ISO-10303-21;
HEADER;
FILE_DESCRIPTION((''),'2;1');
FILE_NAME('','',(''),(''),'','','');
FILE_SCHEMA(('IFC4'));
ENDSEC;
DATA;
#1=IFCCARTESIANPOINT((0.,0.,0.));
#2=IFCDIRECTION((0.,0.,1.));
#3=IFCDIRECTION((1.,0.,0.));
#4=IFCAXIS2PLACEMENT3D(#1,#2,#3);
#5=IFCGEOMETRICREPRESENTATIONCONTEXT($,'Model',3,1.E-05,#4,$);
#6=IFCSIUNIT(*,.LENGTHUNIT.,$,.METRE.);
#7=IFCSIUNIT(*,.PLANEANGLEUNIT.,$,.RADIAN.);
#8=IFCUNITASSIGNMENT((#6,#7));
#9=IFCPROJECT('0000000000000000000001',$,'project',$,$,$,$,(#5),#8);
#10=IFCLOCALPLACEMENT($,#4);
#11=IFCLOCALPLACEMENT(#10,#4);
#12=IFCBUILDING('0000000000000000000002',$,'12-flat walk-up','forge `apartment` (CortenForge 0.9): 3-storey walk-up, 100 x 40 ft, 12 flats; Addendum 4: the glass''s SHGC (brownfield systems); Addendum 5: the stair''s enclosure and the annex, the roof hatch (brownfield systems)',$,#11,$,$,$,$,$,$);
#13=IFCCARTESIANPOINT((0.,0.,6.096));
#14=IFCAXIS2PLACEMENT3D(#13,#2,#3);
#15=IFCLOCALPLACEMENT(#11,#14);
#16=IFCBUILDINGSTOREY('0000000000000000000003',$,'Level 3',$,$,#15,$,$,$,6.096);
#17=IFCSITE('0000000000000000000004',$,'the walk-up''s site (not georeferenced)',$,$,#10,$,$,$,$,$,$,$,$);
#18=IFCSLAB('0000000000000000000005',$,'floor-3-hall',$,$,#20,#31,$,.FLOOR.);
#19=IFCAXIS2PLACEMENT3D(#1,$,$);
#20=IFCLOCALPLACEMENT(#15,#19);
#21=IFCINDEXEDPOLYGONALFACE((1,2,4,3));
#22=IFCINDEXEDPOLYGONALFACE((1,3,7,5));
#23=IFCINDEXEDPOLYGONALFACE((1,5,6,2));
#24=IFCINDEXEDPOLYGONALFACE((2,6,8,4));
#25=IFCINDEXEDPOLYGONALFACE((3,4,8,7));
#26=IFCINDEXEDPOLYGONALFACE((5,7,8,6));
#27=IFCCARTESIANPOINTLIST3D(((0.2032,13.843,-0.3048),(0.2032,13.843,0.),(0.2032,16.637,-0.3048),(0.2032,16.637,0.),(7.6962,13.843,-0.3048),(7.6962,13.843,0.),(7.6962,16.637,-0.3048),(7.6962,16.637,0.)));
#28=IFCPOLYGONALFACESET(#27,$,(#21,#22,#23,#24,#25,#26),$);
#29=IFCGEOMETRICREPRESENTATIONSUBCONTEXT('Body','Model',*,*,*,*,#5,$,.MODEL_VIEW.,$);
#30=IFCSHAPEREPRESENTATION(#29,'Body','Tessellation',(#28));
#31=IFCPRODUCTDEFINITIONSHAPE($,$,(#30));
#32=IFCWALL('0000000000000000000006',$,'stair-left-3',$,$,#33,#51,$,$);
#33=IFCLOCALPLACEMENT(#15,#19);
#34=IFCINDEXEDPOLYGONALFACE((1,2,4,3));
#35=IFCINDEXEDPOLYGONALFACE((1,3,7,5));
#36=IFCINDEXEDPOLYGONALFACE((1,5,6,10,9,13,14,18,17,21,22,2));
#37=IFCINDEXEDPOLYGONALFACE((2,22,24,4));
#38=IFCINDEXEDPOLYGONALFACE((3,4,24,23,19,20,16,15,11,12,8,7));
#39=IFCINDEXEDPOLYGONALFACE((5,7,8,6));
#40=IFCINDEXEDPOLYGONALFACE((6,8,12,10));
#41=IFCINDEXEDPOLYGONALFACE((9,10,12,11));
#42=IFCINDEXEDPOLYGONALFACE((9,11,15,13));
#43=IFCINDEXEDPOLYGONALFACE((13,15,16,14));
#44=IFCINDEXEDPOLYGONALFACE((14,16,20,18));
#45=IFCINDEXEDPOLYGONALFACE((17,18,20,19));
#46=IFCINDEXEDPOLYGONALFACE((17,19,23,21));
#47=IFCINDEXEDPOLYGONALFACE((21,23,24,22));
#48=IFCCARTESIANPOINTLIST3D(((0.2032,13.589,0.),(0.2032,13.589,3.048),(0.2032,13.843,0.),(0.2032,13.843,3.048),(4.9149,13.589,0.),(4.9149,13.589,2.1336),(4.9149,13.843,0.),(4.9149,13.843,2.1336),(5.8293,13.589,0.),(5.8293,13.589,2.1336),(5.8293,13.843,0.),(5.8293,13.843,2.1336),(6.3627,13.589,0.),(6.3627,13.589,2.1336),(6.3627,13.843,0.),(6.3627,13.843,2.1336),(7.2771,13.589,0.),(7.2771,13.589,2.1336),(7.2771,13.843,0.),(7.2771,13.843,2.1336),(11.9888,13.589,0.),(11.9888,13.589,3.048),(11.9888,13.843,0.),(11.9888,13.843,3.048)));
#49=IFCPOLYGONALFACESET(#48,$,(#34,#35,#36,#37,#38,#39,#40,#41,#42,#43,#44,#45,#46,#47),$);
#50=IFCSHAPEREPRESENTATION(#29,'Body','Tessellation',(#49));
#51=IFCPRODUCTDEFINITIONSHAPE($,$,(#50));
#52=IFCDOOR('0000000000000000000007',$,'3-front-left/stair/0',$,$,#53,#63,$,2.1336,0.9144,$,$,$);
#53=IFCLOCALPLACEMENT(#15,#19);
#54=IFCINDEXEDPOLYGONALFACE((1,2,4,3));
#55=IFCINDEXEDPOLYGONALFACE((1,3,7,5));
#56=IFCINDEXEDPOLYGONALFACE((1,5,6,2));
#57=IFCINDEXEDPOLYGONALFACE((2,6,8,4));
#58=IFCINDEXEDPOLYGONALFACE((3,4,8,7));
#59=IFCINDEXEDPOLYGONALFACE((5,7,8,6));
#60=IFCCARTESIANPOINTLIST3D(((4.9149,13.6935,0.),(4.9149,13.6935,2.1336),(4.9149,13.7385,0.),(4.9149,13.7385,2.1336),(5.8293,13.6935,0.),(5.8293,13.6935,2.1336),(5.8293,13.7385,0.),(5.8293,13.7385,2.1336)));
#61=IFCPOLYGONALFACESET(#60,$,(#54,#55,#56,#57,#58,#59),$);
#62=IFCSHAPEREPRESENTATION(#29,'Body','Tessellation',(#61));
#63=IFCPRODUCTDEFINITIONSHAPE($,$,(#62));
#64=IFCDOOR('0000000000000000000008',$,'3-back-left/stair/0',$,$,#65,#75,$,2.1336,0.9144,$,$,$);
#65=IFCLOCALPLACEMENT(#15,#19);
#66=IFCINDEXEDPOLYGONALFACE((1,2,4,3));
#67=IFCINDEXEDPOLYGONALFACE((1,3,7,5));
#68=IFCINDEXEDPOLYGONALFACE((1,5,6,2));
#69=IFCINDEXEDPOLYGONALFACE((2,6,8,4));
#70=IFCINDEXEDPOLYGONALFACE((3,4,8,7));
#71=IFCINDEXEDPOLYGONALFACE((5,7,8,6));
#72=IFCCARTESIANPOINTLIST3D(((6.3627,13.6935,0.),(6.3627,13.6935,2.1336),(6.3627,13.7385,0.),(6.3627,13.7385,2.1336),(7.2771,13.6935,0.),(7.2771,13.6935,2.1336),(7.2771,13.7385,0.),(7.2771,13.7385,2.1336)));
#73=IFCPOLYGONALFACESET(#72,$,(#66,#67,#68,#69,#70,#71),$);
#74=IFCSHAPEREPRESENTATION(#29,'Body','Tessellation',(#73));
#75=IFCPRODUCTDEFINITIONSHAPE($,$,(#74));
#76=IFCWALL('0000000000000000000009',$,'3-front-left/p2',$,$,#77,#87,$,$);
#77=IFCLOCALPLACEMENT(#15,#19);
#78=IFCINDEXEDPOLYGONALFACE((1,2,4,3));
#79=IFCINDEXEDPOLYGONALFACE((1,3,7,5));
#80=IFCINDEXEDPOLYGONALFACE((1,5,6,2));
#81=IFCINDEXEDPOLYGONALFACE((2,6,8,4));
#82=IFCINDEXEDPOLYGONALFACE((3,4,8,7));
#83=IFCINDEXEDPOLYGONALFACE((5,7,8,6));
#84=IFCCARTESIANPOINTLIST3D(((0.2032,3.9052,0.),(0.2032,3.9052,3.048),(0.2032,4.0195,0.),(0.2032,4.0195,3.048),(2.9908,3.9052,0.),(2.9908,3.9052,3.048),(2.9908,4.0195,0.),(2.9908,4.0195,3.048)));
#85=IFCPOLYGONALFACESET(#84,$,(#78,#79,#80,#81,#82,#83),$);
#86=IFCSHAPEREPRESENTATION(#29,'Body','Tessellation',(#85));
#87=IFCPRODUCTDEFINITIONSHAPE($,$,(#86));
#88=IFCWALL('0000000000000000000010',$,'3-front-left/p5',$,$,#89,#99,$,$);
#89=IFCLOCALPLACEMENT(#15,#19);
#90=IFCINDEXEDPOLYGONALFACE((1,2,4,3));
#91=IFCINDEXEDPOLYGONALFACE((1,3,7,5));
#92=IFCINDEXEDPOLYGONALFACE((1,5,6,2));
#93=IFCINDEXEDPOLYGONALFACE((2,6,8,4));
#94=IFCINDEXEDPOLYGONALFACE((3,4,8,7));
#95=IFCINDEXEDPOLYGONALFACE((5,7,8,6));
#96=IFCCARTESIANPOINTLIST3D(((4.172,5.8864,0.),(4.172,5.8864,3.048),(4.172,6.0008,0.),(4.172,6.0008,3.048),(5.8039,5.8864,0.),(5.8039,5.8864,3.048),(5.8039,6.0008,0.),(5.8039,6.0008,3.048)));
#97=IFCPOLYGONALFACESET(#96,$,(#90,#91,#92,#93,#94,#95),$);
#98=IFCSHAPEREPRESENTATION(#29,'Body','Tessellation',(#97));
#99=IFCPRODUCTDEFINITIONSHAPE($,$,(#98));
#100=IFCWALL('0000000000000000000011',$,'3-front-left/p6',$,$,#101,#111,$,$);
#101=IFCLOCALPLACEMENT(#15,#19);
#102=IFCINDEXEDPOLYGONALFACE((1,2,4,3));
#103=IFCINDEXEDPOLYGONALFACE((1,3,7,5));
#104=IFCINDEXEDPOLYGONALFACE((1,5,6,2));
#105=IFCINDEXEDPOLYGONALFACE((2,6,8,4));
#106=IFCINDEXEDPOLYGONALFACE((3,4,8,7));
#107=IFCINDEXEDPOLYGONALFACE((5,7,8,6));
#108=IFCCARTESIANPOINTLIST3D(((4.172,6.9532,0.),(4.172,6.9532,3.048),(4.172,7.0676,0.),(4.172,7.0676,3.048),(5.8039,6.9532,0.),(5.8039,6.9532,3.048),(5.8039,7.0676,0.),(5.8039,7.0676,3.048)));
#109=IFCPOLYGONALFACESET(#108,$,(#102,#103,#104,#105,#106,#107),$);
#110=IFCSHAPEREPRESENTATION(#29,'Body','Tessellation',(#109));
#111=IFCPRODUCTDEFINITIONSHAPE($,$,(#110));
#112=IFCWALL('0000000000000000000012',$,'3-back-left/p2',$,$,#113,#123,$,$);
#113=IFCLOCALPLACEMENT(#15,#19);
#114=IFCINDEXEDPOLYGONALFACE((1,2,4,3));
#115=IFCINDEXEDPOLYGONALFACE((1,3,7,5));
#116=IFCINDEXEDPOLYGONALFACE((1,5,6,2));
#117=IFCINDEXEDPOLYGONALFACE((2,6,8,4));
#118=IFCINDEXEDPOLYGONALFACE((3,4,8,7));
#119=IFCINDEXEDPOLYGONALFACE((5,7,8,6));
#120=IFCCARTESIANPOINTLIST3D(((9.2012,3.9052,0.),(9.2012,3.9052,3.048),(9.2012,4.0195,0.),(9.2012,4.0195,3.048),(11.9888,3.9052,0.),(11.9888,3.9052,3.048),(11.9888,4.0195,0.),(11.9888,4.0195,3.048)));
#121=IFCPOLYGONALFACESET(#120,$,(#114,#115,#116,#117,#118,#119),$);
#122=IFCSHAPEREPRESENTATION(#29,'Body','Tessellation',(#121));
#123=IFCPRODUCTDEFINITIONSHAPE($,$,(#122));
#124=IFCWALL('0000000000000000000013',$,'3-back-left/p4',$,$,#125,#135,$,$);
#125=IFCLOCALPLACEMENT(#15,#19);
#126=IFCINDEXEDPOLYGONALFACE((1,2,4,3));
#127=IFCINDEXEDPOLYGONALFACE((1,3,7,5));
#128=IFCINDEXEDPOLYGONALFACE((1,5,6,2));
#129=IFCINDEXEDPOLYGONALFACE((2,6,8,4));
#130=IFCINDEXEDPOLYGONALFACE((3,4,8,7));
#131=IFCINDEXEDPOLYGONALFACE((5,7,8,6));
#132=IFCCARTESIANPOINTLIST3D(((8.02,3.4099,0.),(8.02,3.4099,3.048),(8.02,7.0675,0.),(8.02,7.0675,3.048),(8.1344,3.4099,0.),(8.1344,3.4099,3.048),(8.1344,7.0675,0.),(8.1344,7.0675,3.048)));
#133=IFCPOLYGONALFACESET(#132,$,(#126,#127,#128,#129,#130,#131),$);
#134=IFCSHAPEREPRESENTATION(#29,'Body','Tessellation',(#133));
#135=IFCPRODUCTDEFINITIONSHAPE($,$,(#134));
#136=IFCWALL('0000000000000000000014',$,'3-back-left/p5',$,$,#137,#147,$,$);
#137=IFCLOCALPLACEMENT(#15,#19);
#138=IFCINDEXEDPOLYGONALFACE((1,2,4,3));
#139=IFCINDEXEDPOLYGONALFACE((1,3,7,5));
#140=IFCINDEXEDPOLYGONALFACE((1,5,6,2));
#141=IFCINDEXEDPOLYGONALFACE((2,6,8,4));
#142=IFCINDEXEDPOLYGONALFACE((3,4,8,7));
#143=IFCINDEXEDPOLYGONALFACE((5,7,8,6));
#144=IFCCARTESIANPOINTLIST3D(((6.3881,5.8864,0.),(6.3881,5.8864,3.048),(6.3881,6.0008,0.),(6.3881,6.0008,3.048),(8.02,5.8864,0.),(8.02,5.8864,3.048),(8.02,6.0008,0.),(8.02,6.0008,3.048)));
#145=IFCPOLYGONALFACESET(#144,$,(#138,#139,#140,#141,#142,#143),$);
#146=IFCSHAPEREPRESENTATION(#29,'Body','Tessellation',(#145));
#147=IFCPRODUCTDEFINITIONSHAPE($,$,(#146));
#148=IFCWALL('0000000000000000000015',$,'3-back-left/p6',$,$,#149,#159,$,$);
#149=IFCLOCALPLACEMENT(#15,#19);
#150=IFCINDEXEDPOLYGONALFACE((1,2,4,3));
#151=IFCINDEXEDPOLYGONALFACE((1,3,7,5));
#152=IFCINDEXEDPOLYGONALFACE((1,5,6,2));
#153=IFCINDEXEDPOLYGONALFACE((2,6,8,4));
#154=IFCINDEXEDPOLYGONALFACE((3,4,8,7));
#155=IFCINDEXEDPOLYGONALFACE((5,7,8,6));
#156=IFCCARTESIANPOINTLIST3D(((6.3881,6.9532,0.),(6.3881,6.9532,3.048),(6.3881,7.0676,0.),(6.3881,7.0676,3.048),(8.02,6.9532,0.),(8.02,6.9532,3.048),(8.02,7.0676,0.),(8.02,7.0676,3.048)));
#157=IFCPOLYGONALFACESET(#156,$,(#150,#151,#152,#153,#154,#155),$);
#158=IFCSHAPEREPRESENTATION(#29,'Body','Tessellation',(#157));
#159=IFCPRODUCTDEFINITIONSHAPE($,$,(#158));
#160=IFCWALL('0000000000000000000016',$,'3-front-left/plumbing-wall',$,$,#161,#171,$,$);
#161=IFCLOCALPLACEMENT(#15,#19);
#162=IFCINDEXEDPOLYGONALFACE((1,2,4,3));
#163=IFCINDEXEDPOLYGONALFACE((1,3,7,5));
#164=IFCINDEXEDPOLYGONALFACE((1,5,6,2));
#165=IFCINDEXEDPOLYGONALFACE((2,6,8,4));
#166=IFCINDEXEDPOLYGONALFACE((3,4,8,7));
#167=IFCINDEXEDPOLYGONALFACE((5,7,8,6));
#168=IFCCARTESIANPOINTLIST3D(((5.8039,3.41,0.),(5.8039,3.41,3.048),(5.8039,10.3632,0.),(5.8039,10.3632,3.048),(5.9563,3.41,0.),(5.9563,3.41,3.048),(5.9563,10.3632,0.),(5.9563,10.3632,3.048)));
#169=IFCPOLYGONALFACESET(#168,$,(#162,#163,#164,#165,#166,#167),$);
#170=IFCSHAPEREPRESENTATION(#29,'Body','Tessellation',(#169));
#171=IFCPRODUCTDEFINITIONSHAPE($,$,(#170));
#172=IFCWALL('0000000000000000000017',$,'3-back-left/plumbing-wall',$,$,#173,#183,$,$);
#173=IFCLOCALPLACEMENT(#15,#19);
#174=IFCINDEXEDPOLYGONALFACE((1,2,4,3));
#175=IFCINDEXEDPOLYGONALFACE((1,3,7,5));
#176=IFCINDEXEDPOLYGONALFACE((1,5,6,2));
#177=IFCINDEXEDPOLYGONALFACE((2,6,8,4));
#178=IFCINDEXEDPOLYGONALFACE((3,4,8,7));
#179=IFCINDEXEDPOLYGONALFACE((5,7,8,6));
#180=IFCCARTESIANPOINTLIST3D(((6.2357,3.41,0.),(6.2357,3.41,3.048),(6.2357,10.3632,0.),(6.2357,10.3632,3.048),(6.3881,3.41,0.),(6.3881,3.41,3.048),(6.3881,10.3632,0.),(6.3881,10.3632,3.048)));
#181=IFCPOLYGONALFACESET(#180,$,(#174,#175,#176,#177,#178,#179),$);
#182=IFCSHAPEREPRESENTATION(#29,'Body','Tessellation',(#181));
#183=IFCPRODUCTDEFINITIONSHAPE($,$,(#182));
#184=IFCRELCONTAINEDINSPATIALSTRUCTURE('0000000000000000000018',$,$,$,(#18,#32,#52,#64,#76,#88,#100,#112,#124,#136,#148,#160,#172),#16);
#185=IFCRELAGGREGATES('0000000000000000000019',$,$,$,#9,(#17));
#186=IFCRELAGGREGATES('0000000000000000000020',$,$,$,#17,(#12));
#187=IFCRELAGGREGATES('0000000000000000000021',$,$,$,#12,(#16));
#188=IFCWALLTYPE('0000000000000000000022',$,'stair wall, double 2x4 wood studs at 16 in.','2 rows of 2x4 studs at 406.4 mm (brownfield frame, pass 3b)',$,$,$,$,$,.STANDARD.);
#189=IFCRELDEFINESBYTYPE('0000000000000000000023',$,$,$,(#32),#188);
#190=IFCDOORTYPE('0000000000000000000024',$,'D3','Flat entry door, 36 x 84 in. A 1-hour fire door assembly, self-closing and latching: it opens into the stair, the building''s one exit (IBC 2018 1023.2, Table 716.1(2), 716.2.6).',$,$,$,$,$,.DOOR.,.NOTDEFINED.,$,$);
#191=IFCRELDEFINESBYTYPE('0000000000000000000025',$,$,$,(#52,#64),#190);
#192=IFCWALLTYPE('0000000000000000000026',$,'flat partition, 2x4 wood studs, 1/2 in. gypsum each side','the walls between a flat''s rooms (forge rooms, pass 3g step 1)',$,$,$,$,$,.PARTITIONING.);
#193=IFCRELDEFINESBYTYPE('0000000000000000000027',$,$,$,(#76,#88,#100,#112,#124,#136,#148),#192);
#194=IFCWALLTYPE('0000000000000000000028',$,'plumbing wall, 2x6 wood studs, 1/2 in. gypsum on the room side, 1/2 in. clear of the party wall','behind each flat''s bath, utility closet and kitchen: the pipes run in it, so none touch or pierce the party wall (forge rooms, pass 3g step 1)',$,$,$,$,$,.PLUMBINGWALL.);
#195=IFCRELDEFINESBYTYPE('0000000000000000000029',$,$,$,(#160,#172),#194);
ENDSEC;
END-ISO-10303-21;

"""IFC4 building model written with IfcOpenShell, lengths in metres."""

from ifc_helpers import new_model, si_unit, frame, frame_2d, origin, origin_with_axes, place, context, subcontext, project, spatial, rectangle, extrude, type_object, element, fill, save


model = new_model("IFC4")

# Units and contexts
model_context = context("Model", 3, precision=1e-05, world=origin_with_axes())
body_context = subcontext(model_context, "Body", "Model", "MODEL_VIEW")
ifc_project = project(units=[si_unit("LENGTHUNIT", "METRE"), si_unit("PLANEANGLEUNIT", "RADIAN")], contexts=[model_context])

# Site, building, storey
site_placement = place(None, origin_with_axes())
site = spatial("IfcSite", under=ifc_project, at=site_placement, Name="the walk-up's site (not georeferenced)")
building_placement = place(site_placement, origin_with_axes())
building = spatial("IfcBuilding", under=site, at=building_placement, Name="12-flat walk-up", Description="forge `apartment` (CortenForge 0.9): 3-storey walk-up, 100 x 40 ft, 12 flats; Addendum 4: the glass's SHGC (brownfield systems); Addendum 5: the stair's enclosure and the annex, the roof hatch (brownfield systems)")
storey_placement = place(building_placement, frame((0.0, 0.0, 6.096), z_axis=(0.0, 0.0, 1.0), x_axis=(1.0, 0.0, 0.0)))
storey = spatial("IfcBuildingStorey", under=building, at=storey_placement, Name="Level 3", Elevation=6.096)

# Slab
slab_placement = place(storey_placement, frame((0.2032, 13.843, -0.3048), z_axis=(0.0, 0.0, 1.0), x_axis=(1.0, 0.0, 0.0)))
element("IfcSlab", 1, at=slab_placement, inside=storey, Name="floor-3-hall", PredefinedType="FLOOR", context=body_context, shape_type="SweptSolid", body=[
    extrude(rectangle(XDim=7.493, YDim=2.794, at=frame_2d((3.7465, 1.397))), origin(), (0.0, 0.0, 1.0), 0.3048),
])

# Wall, openings, doors
wall_type_1 = type_object("IfcWallType", Name="stair wall, double 2x4 wood studs at 16 in.", Description="2 rows of 2x4 studs at 406.4 mm (brownfield frame, pass 3b)", PredefinedType="STANDARD")
wall_1_placement = place(storey_placement, frame((0.2032, 13.589, 0.0), z_axis=(0.0, 0.0, 1.0), x_axis=(1.0, 0.0, 0.0)))
wall_1 = element("IfcWall", 2, at=wall_1_placement, inside=storey, type_object=wall_type_1, Name="stair-left-3", context=body_context, shape_type="SweptSolid", body=[
    extrude(rectangle(XDim=11.7856, YDim=0.254, at=frame_2d((5.8928, 0.127))), origin(), (0.0, 0.0, 1.0), 3.048),
])
opening_1_placement = place(wall_1_placement, frame((4.7117, 0.0, 0.0), z_axis=(0.0, 0.0, 1.0), x_axis=(1.0, 0.0, 0.0)))
opening_1 = element("IfcOpeningElement", 3, at=opening_1_placement, cuts=wall_1, PredefinedType="OPENING", context=body_context, shape_type="SweptSolid", body=[
    extrude(rectangle(XDim=0.9144, YDim=0.254, at=frame_2d((0.4572, 0.127))), origin(), (0.0, 0.0, 1.0), 2.1336),
])
opening_2_placement = place(wall_1_placement, frame((6.1595, 0.0, 0.0), z_axis=(0.0, 0.0, 1.0), x_axis=(1.0, 0.0, 0.0)))
opening_2 = element("IfcOpeningElement", 4, at=opening_2_placement, cuts=wall_1, PredefinedType="OPENING", context=body_context, shape_type="SweptSolid", body=[
    extrude(rectangle(XDim=0.9144, YDim=0.254, at=frame_2d((0.4572, 0.127))), origin(), (0.0, 0.0, 1.0), 2.1336),
])
door_type = type_object("IfcDoorType", Name="D3", Description="Flat entry door, 36 x 84 in. A 1-hour fire door assembly, self-closing and latching: it opens into the stair, the building's one exit (IBC 2018 1023.2, Table 716.1(2), 716.2.6).", OperationType="NOTDEFINED", PredefinedType="DOOR")
door_1_placement = place(opening_1_placement, frame((0.0, 0.1045, 0.0), z_axis=(0.0, 0.0, 1.0), x_axis=(1.0, 0.0, 0.0)))
door_1 = element("IfcDoor", 5, at=door_1_placement, inside=storey, type_object=door_type, Name="3-front-left/stair/0", OverallHeight=2.1336, OverallWidth=0.9144, context=body_context, shape_type="SweptSolid", body=[
    extrude(rectangle(XDim=0.9144, YDim=0.045, at=frame_2d((0.4572, 0.0225))), origin(), (0.0, 0.0, 1.0), 2.1336),
])
fill(opening_1, door_1)
door_2_placement = place(opening_2_placement, frame((0.0, 0.1045, 0.0), z_axis=(0.0, 0.0, 1.0), x_axis=(1.0, 0.0, 0.0)))
door_2 = element("IfcDoor", 6, at=door_2_placement, inside=storey, type_object=door_type, Name="3-back-left/stair/0", OverallHeight=2.1336, OverallWidth=0.9144, context=body_context, shape_type="SweptSolid", body=[
    extrude(rectangle(XDim=0.9144, YDim=0.045, at=frame_2d((0.4572, 0.0225))), origin(), (0.0, 0.0, 1.0), 2.1336),
])
fill(opening_2, door_2)

# Walls
wall_type_2 = type_object("IfcWallType", Name="flat partition, 2x4 wood studs, 1/2 in. gypsum each side", Description="the walls between a flat's rooms (forge rooms, pass 3g step 1)", PredefinedType="PARTITIONING")
wall_2_placement = place(storey_placement, frame((0.2032, 3.9052, 0.0), z_axis=(0.0, 0.0, 1.0), x_axis=(1.0, 0.0, 0.0)))
element("IfcWall", 7, at=wall_2_placement, inside=storey, type_object=wall_type_2, Name="3-front-left/p2", context=body_context, shape_type="SweptSolid", body=[
    extrude(rectangle(XDim=2.7877, YDim=0.1143, at=frame_2d((1.3938, 0.0571))), origin(), (0.0, 0.0, 1.0), 3.048),
])
for number, where, z_axis, x_axis, name in (
    (8, (4.1719, 5.8864, 0.0), (0.0, 0.0, 1.0), (1.0, 0.0, 0.0), "3-front-left/p5"),
    (9, (4.1719, 6.9532, 0.0), (0.0, 0.0, 1.0), (1.0, 0.0, 0.0), "3-front-left/p6"),
):
    element("IfcWall", number, at=place(storey_placement, frame(where, z_axis=z_axis, x_axis=x_axis)), inside=storey, type_object=wall_type_2, Name=name, context=body_context, shape_type="SweptSolid", body=[
        extrude(rectangle(XDim=1.6319, YDim=0.1143, at=frame_2d((0.816, 0.0572))), origin(), (0.0, 0.0, 1.0), 3.048),
    ])
wall_3_placement = place(storey_placement, frame((9.2012, 3.9052, 0.0), z_axis=(0.0, 0.0, 1.0), x_axis=(1.0, 0.0, 0.0)))
element("IfcWall", 10, at=wall_3_placement, inside=storey, type_object=wall_type_2, Name="3-back-left/p2", context=body_context, shape_type="SweptSolid", body=[
    extrude(rectangle(XDim=2.7876, YDim=0.1143, at=frame_2d((1.3938, 0.0571))), origin(), (0.0, 0.0, 1.0), 3.048),
])
wall_4_placement = place(storey_placement, frame((8.02, 3.4099, 0.0), z_axis=(0.0, 0.0, 1.0), x_axis=(1.0, 0.0, 0.0)))
element("IfcWall", 11, at=wall_4_placement, inside=storey, type_object=wall_type_2, Name="3-back-left/p4", context=body_context, shape_type="SweptSolid", body=[
    extrude(rectangle(XDim=0.1143, YDim=3.6576, at=frame_2d((0.0572, 1.8288))), origin(), (0.0, 0.0, 1.0), 3.048),
])
for number, where, z_axis, x_axis, name in (
    (12, (6.3881, 5.8864, 0.0), (0.0, 0.0, 1.0), (1.0, 0.0, 0.0), "3-back-left/p5"),
    (13, (6.3881, 6.9532, 0.0), (0.0, 0.0, 1.0), (1.0, 0.0, 0.0), "3-back-left/p6"),
):
    element("IfcWall", number, at=place(storey_placement, frame(where, z_axis=z_axis, x_axis=x_axis)), inside=storey, type_object=wall_type_2, Name=name, context=body_context, shape_type="SweptSolid", body=[
        extrude(rectangle(XDim=1.6319, YDim=0.1143, at=frame_2d((0.816, 0.0572))), origin(), (0.0, 0.0, 1.0), 3.048),
    ])
wall_type_3 = type_object("IfcWallType", Name="plumbing wall, 2x6 wood studs, 1/2 in. gypsum on the room side, 1/2 in. clear of the party wall", Description="behind each flat's bath, utility closet and kitchen: the pipes run in it, so none touch or pierce the party wall (forge rooms, pass 3g step 1)", PredefinedType="PLUMBINGWALL")
for number, where, z_axis, x_axis, name in (
    (14, (5.8039, 3.41, 0.0), (0.0, 0.0, 1.0), (1.0, 0.0, 0.0), "3-front-left/plumbing-wall"),
    (15, (6.2357, 3.41, 0.0), (0.0, 0.0, 1.0), (1.0, 0.0, 0.0), "3-back-left/plumbing-wall"),
):
    element("IfcWall", number, at=place(storey_placement, frame(where, z_axis=z_axis, x_axis=x_axis)), inside=storey, type_object=wall_type_3, Name=name, context=body_context, shape_type="SweptSolid", body=[
        extrude(rectangle(XDim=0.1524, YDim=6.9533, at=frame_2d((0.0762, 3.4766))), origin(), (0.0, 0.0, 1.0), 3.048),
    ])

save(model, "model.ifc")
